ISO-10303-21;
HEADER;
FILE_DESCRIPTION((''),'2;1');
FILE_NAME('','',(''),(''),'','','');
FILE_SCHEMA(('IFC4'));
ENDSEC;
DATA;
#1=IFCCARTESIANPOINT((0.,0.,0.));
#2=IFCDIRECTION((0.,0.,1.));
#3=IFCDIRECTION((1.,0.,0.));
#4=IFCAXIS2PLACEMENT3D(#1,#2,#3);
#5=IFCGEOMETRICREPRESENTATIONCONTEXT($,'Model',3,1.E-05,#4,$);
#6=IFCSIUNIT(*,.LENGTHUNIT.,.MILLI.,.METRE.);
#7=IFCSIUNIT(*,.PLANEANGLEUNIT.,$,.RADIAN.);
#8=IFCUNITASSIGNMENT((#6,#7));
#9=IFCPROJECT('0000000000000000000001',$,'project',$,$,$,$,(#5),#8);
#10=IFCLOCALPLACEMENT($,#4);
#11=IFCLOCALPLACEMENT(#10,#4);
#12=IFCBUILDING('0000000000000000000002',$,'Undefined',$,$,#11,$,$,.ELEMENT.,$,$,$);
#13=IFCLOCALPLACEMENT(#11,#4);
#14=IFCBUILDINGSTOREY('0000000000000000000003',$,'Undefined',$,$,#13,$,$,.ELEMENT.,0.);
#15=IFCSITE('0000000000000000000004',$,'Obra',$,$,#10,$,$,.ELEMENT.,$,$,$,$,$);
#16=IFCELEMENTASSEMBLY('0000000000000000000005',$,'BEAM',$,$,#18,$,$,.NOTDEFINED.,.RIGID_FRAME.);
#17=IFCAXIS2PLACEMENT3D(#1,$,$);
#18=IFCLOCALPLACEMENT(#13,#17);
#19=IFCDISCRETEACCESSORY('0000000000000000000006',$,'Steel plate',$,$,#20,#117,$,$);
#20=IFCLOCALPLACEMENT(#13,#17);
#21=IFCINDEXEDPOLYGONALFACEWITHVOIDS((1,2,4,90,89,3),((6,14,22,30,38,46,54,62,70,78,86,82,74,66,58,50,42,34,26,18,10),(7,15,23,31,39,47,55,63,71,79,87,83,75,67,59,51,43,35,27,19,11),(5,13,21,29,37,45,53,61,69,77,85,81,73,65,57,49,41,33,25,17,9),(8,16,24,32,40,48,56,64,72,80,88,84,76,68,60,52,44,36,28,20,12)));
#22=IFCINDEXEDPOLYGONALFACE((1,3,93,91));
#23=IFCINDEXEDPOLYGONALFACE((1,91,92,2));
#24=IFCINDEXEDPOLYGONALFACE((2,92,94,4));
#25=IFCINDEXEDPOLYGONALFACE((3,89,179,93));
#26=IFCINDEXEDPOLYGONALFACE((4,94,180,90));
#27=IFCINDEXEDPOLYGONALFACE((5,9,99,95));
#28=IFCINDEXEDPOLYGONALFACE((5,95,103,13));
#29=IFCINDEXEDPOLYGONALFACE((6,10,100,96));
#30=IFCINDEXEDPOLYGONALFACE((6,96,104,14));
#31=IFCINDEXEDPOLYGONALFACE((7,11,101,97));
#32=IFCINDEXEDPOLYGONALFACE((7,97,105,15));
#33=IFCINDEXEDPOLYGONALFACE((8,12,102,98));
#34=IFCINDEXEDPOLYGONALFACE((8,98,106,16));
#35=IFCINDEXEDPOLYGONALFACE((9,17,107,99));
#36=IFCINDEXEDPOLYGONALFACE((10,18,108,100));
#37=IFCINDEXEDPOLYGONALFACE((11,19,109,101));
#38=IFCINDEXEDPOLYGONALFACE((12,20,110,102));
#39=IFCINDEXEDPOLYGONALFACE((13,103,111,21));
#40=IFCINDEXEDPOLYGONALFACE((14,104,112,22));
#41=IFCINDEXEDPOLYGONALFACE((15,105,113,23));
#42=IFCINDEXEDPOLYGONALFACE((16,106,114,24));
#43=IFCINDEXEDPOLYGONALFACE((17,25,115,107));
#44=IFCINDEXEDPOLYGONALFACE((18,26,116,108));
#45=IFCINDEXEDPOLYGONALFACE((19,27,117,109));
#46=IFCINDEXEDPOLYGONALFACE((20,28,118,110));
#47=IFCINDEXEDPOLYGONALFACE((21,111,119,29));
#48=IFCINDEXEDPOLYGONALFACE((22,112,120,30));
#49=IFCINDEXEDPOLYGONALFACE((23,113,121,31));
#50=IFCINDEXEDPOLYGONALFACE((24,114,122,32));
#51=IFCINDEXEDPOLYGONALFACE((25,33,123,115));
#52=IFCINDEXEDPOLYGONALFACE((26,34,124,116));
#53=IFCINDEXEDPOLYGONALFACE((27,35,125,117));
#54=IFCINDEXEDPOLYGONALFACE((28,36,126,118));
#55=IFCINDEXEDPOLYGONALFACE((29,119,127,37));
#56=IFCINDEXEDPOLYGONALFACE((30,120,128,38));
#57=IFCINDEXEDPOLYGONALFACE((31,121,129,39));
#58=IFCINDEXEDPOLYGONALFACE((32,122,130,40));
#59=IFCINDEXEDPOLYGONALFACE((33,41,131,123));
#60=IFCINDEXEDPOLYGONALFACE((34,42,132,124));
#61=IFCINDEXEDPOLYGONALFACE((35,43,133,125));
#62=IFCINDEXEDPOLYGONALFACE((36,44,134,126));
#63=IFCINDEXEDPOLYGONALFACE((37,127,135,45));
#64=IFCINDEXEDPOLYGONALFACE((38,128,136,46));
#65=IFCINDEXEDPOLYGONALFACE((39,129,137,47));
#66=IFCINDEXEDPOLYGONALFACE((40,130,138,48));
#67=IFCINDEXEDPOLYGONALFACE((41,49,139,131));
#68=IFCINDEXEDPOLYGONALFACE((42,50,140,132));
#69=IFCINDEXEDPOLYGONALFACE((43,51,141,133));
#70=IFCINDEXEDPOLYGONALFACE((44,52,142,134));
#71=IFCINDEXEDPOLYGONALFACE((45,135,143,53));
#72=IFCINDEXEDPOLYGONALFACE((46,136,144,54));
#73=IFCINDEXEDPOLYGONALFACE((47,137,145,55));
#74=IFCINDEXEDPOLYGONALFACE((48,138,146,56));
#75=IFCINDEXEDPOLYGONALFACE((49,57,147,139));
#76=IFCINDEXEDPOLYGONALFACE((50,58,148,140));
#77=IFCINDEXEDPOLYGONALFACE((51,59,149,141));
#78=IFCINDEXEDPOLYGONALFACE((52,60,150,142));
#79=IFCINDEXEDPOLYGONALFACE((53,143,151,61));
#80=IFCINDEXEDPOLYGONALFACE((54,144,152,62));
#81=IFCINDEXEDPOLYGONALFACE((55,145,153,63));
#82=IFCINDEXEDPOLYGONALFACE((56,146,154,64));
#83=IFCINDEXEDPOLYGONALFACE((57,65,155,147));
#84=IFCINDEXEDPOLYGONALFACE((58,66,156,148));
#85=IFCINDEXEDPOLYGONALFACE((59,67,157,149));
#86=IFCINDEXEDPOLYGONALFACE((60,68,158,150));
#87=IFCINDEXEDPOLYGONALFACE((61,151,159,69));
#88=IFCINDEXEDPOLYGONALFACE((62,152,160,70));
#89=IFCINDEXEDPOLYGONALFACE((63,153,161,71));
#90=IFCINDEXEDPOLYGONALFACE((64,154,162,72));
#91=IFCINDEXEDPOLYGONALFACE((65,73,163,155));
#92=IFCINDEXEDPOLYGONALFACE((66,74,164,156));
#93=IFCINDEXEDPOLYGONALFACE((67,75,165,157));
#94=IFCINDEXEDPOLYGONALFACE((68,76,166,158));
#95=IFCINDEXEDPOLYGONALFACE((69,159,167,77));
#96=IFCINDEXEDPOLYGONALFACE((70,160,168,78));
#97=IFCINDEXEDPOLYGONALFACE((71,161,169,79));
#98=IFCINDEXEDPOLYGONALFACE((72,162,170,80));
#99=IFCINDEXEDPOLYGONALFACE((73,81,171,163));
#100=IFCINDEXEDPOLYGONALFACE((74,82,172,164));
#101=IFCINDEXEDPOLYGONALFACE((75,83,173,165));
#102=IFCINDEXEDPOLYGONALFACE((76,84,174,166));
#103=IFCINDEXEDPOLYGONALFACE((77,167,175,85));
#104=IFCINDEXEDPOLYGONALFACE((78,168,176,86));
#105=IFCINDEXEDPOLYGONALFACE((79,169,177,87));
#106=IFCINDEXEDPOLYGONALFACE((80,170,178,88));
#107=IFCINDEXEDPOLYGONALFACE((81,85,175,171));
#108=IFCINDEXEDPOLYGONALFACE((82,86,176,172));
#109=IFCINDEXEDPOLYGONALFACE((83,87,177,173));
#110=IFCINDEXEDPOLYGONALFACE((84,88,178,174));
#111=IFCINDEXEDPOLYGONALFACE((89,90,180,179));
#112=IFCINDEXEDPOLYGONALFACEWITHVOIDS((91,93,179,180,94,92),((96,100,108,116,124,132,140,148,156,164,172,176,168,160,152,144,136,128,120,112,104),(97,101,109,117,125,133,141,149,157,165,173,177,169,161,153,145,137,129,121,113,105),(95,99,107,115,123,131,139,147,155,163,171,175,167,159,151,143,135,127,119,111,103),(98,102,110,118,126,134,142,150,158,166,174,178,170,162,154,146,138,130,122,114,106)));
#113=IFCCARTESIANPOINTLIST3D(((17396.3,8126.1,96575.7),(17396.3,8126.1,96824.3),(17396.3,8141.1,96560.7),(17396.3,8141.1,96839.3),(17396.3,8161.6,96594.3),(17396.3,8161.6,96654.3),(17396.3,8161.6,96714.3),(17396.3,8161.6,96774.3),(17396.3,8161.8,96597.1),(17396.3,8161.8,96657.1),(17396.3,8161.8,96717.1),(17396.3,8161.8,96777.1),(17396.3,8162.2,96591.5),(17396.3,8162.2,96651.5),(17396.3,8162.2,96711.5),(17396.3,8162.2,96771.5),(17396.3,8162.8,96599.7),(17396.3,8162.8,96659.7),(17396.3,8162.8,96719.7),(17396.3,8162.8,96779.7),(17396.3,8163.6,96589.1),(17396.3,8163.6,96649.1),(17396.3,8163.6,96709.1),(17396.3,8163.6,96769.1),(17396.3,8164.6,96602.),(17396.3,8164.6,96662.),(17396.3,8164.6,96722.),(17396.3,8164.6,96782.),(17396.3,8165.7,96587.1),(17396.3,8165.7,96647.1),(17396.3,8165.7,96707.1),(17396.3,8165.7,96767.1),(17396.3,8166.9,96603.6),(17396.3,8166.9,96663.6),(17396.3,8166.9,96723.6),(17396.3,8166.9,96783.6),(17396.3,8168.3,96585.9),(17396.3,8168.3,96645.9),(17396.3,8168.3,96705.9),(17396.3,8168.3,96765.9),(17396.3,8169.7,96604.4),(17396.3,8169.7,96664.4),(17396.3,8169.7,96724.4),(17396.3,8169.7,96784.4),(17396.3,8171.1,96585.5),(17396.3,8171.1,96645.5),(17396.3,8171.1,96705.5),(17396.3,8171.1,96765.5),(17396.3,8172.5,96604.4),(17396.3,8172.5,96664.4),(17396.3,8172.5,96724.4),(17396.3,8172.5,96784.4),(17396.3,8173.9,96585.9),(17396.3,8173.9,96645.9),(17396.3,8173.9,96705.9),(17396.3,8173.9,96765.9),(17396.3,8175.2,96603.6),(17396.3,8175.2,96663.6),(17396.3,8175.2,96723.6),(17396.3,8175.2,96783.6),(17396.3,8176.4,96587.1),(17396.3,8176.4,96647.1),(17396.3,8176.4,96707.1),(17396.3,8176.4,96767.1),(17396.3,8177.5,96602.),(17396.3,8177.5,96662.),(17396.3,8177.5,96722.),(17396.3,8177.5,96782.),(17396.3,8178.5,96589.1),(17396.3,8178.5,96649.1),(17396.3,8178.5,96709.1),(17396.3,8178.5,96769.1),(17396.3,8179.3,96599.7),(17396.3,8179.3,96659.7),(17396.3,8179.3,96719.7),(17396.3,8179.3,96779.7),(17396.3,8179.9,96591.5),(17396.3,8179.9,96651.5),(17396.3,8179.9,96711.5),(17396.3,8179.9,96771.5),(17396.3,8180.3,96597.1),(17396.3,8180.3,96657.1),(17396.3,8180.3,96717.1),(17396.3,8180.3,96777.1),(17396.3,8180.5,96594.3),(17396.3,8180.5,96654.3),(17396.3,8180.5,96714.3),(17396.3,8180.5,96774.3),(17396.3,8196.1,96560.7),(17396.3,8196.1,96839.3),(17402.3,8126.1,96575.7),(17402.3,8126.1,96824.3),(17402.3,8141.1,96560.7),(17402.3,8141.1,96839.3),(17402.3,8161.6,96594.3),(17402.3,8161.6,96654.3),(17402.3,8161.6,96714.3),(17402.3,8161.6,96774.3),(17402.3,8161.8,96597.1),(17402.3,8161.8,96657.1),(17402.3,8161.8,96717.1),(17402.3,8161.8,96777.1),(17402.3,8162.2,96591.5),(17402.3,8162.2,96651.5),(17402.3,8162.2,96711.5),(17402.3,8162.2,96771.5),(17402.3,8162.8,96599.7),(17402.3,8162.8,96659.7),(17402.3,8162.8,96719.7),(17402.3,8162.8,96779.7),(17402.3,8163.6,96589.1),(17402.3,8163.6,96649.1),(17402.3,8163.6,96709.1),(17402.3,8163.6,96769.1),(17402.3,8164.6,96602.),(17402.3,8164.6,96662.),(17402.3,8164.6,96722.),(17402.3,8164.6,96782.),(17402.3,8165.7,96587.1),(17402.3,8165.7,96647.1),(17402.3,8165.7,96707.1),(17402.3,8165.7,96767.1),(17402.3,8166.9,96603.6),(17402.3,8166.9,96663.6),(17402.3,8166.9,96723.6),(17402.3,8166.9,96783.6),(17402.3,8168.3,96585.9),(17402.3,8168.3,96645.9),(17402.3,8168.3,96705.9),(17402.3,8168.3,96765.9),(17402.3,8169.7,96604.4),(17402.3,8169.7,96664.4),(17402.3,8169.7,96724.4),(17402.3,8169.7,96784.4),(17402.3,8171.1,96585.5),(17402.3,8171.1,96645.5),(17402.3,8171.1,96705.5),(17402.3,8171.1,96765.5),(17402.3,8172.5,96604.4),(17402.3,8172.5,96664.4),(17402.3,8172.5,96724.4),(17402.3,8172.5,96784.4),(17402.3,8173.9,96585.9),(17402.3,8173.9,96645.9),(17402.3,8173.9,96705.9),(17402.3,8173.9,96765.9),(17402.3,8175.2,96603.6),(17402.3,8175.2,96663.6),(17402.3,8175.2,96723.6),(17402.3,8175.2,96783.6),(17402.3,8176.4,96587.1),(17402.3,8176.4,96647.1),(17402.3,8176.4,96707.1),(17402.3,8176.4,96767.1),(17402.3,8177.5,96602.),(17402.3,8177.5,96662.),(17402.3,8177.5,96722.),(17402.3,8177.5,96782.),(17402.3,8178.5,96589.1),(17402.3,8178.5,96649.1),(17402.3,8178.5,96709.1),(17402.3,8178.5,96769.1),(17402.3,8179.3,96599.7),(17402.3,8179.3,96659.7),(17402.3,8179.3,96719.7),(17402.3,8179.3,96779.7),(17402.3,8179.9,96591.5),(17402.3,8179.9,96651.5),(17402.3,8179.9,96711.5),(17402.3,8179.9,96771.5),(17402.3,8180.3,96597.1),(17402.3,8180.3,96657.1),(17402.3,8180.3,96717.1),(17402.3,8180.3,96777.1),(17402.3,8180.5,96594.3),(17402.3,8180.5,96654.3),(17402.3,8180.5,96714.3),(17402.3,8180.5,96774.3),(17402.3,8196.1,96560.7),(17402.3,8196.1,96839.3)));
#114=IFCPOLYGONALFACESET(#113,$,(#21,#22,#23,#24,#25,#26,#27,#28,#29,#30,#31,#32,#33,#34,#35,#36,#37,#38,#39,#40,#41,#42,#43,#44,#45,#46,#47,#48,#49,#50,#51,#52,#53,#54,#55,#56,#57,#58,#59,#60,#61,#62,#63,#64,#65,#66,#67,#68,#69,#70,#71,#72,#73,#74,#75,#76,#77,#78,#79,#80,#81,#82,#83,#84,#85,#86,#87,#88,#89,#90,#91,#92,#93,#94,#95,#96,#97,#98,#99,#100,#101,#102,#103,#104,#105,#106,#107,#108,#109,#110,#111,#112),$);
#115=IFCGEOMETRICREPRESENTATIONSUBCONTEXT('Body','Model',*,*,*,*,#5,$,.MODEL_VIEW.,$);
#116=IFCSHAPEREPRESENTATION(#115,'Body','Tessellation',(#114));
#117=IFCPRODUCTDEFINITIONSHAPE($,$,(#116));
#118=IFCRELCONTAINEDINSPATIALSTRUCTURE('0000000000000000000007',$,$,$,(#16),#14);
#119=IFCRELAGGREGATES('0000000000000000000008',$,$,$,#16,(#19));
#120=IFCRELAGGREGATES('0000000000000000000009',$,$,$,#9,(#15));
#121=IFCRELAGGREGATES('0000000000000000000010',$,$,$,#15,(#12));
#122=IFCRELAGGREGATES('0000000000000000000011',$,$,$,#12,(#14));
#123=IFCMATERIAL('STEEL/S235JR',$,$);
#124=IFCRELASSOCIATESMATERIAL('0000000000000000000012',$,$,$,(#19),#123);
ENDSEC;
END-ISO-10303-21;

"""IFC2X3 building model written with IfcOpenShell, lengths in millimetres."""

from ifc_helpers import new_model, si_unit, frame, origin_with_axes, origin_2d_with_axis, place, context, subcontext, project, spatial, polyline, circle, outline, extrude, source, transform, mapped, material, element, aggregate, save


model = new_model("IFC2X3")

# Units and contexts
model_context = context("Model", 3, precision=1e-05, world=origin_with_axes())
body_context = subcontext(model_context, "Body", "Model", "MODEL_VIEW")
ifc_project = project(units=[si_unit("LENGTHUNIT", "METRE", prefix="MILLI"), si_unit("PLANEANGLEUNIT", "RADIAN")], contexts=[model_context])

# Site, building, storey
site_placement = place(None, origin_with_axes())
site = spatial("IfcSite", under=ifc_project, at=site_placement, Name="Obra", CompositionType="ELEMENT")
building_placement = place(site_placement, origin_with_axes())
building = spatial("IfcBuilding", under=site, at=building_placement, Name="Undefined", CompositionType="ELEMENT")
storey_placement = place(building_placement, origin_with_axes())
storey = spatial("IfcBuildingStorey", under=building, at=storey_placement, Name="Undefined", CompositionType="ELEMENT", Elevation=0.0)

# Element assembly, discrete accessory, opening
ifc_material_1 = material(Name="STEEL/S235JR")
shared_shape_1 = source(origin_with_axes(), body_context, "Body", "SweptSolid", [
    extrude(circle(Radius=9.5, at=origin_2d_with_axis()), frame((0.0, -9.8, 0.0), z_axis=(0.0, 1.0, 0.0), x_axis=(1.0, 0.0, 0.0)), (0.0, 0.0, 1.0), 6.2),
])
assembly_1_placement = place(storey_placement, origin_with_axes())
assembly_1 = element("IfcElementAssembly", 1, at=assembly_1_placement, inside=storey, Name="BEAM", AssemblyPlace="NOTDEFINED", PredefinedType="RIGID_FRAME")
discrete_accessory_1_placement = place(assembly_1_placement, frame((17399.3, 8196.1, 96560.7), z_axis=(-1.0, 0.0, 0.0), x_axis=(0.0, -1.0, 0.0)))
discrete_accessory_1 = element("IfcDiscreteAccessory", 2, at=discrete_accessory_1_placement, material=ifc_material_1, Name="Steel plate", context=body_context, shape_type="SweptSolid", body=[
    extrude(outline(polyline([(0.0, 0.0), (55.0, 0.0), (70.0, 15.0), (70.0, 263.6), (55.0, 278.6), (0.0, 278.6), (0.0, 0.0)])), frame((0.0, 0.0, -3.0), z_axis=(0.0, 0.0, 1.0), x_axis=(1.0, 0.0, 0.0)), (0.0, 0.0, 1.0), 6.0),
])
opening_1_placement = place(assembly_1_placement, frame((17392.6, 8136.1, 96850.0), z_axis=(0.0, 1.0, 0.0), x_axis=(0.0, 0.0, -1.0)))
element("IfcOpeningElement", 3, at=opening_1_placement, cuts=discrete_accessory_1, ObjectType="Opening", context=body_context, shape_type="MappedRepresentation", body=[
    mapped(shared_shape_1, transform((75.0, 0.0, 35.0))),
    mapped(shared_shape_1, transform((135.0, 0.0, 35.0))),
    mapped(shared_shape_1, transform((195.0, 0.0, 35.0))),
    mapped(shared_shape_1, transform((255.0, 0.0, 35.0))),
])

aggregate(assembly_1, [discrete_accessory_1])

save(model, "model.ifc")
